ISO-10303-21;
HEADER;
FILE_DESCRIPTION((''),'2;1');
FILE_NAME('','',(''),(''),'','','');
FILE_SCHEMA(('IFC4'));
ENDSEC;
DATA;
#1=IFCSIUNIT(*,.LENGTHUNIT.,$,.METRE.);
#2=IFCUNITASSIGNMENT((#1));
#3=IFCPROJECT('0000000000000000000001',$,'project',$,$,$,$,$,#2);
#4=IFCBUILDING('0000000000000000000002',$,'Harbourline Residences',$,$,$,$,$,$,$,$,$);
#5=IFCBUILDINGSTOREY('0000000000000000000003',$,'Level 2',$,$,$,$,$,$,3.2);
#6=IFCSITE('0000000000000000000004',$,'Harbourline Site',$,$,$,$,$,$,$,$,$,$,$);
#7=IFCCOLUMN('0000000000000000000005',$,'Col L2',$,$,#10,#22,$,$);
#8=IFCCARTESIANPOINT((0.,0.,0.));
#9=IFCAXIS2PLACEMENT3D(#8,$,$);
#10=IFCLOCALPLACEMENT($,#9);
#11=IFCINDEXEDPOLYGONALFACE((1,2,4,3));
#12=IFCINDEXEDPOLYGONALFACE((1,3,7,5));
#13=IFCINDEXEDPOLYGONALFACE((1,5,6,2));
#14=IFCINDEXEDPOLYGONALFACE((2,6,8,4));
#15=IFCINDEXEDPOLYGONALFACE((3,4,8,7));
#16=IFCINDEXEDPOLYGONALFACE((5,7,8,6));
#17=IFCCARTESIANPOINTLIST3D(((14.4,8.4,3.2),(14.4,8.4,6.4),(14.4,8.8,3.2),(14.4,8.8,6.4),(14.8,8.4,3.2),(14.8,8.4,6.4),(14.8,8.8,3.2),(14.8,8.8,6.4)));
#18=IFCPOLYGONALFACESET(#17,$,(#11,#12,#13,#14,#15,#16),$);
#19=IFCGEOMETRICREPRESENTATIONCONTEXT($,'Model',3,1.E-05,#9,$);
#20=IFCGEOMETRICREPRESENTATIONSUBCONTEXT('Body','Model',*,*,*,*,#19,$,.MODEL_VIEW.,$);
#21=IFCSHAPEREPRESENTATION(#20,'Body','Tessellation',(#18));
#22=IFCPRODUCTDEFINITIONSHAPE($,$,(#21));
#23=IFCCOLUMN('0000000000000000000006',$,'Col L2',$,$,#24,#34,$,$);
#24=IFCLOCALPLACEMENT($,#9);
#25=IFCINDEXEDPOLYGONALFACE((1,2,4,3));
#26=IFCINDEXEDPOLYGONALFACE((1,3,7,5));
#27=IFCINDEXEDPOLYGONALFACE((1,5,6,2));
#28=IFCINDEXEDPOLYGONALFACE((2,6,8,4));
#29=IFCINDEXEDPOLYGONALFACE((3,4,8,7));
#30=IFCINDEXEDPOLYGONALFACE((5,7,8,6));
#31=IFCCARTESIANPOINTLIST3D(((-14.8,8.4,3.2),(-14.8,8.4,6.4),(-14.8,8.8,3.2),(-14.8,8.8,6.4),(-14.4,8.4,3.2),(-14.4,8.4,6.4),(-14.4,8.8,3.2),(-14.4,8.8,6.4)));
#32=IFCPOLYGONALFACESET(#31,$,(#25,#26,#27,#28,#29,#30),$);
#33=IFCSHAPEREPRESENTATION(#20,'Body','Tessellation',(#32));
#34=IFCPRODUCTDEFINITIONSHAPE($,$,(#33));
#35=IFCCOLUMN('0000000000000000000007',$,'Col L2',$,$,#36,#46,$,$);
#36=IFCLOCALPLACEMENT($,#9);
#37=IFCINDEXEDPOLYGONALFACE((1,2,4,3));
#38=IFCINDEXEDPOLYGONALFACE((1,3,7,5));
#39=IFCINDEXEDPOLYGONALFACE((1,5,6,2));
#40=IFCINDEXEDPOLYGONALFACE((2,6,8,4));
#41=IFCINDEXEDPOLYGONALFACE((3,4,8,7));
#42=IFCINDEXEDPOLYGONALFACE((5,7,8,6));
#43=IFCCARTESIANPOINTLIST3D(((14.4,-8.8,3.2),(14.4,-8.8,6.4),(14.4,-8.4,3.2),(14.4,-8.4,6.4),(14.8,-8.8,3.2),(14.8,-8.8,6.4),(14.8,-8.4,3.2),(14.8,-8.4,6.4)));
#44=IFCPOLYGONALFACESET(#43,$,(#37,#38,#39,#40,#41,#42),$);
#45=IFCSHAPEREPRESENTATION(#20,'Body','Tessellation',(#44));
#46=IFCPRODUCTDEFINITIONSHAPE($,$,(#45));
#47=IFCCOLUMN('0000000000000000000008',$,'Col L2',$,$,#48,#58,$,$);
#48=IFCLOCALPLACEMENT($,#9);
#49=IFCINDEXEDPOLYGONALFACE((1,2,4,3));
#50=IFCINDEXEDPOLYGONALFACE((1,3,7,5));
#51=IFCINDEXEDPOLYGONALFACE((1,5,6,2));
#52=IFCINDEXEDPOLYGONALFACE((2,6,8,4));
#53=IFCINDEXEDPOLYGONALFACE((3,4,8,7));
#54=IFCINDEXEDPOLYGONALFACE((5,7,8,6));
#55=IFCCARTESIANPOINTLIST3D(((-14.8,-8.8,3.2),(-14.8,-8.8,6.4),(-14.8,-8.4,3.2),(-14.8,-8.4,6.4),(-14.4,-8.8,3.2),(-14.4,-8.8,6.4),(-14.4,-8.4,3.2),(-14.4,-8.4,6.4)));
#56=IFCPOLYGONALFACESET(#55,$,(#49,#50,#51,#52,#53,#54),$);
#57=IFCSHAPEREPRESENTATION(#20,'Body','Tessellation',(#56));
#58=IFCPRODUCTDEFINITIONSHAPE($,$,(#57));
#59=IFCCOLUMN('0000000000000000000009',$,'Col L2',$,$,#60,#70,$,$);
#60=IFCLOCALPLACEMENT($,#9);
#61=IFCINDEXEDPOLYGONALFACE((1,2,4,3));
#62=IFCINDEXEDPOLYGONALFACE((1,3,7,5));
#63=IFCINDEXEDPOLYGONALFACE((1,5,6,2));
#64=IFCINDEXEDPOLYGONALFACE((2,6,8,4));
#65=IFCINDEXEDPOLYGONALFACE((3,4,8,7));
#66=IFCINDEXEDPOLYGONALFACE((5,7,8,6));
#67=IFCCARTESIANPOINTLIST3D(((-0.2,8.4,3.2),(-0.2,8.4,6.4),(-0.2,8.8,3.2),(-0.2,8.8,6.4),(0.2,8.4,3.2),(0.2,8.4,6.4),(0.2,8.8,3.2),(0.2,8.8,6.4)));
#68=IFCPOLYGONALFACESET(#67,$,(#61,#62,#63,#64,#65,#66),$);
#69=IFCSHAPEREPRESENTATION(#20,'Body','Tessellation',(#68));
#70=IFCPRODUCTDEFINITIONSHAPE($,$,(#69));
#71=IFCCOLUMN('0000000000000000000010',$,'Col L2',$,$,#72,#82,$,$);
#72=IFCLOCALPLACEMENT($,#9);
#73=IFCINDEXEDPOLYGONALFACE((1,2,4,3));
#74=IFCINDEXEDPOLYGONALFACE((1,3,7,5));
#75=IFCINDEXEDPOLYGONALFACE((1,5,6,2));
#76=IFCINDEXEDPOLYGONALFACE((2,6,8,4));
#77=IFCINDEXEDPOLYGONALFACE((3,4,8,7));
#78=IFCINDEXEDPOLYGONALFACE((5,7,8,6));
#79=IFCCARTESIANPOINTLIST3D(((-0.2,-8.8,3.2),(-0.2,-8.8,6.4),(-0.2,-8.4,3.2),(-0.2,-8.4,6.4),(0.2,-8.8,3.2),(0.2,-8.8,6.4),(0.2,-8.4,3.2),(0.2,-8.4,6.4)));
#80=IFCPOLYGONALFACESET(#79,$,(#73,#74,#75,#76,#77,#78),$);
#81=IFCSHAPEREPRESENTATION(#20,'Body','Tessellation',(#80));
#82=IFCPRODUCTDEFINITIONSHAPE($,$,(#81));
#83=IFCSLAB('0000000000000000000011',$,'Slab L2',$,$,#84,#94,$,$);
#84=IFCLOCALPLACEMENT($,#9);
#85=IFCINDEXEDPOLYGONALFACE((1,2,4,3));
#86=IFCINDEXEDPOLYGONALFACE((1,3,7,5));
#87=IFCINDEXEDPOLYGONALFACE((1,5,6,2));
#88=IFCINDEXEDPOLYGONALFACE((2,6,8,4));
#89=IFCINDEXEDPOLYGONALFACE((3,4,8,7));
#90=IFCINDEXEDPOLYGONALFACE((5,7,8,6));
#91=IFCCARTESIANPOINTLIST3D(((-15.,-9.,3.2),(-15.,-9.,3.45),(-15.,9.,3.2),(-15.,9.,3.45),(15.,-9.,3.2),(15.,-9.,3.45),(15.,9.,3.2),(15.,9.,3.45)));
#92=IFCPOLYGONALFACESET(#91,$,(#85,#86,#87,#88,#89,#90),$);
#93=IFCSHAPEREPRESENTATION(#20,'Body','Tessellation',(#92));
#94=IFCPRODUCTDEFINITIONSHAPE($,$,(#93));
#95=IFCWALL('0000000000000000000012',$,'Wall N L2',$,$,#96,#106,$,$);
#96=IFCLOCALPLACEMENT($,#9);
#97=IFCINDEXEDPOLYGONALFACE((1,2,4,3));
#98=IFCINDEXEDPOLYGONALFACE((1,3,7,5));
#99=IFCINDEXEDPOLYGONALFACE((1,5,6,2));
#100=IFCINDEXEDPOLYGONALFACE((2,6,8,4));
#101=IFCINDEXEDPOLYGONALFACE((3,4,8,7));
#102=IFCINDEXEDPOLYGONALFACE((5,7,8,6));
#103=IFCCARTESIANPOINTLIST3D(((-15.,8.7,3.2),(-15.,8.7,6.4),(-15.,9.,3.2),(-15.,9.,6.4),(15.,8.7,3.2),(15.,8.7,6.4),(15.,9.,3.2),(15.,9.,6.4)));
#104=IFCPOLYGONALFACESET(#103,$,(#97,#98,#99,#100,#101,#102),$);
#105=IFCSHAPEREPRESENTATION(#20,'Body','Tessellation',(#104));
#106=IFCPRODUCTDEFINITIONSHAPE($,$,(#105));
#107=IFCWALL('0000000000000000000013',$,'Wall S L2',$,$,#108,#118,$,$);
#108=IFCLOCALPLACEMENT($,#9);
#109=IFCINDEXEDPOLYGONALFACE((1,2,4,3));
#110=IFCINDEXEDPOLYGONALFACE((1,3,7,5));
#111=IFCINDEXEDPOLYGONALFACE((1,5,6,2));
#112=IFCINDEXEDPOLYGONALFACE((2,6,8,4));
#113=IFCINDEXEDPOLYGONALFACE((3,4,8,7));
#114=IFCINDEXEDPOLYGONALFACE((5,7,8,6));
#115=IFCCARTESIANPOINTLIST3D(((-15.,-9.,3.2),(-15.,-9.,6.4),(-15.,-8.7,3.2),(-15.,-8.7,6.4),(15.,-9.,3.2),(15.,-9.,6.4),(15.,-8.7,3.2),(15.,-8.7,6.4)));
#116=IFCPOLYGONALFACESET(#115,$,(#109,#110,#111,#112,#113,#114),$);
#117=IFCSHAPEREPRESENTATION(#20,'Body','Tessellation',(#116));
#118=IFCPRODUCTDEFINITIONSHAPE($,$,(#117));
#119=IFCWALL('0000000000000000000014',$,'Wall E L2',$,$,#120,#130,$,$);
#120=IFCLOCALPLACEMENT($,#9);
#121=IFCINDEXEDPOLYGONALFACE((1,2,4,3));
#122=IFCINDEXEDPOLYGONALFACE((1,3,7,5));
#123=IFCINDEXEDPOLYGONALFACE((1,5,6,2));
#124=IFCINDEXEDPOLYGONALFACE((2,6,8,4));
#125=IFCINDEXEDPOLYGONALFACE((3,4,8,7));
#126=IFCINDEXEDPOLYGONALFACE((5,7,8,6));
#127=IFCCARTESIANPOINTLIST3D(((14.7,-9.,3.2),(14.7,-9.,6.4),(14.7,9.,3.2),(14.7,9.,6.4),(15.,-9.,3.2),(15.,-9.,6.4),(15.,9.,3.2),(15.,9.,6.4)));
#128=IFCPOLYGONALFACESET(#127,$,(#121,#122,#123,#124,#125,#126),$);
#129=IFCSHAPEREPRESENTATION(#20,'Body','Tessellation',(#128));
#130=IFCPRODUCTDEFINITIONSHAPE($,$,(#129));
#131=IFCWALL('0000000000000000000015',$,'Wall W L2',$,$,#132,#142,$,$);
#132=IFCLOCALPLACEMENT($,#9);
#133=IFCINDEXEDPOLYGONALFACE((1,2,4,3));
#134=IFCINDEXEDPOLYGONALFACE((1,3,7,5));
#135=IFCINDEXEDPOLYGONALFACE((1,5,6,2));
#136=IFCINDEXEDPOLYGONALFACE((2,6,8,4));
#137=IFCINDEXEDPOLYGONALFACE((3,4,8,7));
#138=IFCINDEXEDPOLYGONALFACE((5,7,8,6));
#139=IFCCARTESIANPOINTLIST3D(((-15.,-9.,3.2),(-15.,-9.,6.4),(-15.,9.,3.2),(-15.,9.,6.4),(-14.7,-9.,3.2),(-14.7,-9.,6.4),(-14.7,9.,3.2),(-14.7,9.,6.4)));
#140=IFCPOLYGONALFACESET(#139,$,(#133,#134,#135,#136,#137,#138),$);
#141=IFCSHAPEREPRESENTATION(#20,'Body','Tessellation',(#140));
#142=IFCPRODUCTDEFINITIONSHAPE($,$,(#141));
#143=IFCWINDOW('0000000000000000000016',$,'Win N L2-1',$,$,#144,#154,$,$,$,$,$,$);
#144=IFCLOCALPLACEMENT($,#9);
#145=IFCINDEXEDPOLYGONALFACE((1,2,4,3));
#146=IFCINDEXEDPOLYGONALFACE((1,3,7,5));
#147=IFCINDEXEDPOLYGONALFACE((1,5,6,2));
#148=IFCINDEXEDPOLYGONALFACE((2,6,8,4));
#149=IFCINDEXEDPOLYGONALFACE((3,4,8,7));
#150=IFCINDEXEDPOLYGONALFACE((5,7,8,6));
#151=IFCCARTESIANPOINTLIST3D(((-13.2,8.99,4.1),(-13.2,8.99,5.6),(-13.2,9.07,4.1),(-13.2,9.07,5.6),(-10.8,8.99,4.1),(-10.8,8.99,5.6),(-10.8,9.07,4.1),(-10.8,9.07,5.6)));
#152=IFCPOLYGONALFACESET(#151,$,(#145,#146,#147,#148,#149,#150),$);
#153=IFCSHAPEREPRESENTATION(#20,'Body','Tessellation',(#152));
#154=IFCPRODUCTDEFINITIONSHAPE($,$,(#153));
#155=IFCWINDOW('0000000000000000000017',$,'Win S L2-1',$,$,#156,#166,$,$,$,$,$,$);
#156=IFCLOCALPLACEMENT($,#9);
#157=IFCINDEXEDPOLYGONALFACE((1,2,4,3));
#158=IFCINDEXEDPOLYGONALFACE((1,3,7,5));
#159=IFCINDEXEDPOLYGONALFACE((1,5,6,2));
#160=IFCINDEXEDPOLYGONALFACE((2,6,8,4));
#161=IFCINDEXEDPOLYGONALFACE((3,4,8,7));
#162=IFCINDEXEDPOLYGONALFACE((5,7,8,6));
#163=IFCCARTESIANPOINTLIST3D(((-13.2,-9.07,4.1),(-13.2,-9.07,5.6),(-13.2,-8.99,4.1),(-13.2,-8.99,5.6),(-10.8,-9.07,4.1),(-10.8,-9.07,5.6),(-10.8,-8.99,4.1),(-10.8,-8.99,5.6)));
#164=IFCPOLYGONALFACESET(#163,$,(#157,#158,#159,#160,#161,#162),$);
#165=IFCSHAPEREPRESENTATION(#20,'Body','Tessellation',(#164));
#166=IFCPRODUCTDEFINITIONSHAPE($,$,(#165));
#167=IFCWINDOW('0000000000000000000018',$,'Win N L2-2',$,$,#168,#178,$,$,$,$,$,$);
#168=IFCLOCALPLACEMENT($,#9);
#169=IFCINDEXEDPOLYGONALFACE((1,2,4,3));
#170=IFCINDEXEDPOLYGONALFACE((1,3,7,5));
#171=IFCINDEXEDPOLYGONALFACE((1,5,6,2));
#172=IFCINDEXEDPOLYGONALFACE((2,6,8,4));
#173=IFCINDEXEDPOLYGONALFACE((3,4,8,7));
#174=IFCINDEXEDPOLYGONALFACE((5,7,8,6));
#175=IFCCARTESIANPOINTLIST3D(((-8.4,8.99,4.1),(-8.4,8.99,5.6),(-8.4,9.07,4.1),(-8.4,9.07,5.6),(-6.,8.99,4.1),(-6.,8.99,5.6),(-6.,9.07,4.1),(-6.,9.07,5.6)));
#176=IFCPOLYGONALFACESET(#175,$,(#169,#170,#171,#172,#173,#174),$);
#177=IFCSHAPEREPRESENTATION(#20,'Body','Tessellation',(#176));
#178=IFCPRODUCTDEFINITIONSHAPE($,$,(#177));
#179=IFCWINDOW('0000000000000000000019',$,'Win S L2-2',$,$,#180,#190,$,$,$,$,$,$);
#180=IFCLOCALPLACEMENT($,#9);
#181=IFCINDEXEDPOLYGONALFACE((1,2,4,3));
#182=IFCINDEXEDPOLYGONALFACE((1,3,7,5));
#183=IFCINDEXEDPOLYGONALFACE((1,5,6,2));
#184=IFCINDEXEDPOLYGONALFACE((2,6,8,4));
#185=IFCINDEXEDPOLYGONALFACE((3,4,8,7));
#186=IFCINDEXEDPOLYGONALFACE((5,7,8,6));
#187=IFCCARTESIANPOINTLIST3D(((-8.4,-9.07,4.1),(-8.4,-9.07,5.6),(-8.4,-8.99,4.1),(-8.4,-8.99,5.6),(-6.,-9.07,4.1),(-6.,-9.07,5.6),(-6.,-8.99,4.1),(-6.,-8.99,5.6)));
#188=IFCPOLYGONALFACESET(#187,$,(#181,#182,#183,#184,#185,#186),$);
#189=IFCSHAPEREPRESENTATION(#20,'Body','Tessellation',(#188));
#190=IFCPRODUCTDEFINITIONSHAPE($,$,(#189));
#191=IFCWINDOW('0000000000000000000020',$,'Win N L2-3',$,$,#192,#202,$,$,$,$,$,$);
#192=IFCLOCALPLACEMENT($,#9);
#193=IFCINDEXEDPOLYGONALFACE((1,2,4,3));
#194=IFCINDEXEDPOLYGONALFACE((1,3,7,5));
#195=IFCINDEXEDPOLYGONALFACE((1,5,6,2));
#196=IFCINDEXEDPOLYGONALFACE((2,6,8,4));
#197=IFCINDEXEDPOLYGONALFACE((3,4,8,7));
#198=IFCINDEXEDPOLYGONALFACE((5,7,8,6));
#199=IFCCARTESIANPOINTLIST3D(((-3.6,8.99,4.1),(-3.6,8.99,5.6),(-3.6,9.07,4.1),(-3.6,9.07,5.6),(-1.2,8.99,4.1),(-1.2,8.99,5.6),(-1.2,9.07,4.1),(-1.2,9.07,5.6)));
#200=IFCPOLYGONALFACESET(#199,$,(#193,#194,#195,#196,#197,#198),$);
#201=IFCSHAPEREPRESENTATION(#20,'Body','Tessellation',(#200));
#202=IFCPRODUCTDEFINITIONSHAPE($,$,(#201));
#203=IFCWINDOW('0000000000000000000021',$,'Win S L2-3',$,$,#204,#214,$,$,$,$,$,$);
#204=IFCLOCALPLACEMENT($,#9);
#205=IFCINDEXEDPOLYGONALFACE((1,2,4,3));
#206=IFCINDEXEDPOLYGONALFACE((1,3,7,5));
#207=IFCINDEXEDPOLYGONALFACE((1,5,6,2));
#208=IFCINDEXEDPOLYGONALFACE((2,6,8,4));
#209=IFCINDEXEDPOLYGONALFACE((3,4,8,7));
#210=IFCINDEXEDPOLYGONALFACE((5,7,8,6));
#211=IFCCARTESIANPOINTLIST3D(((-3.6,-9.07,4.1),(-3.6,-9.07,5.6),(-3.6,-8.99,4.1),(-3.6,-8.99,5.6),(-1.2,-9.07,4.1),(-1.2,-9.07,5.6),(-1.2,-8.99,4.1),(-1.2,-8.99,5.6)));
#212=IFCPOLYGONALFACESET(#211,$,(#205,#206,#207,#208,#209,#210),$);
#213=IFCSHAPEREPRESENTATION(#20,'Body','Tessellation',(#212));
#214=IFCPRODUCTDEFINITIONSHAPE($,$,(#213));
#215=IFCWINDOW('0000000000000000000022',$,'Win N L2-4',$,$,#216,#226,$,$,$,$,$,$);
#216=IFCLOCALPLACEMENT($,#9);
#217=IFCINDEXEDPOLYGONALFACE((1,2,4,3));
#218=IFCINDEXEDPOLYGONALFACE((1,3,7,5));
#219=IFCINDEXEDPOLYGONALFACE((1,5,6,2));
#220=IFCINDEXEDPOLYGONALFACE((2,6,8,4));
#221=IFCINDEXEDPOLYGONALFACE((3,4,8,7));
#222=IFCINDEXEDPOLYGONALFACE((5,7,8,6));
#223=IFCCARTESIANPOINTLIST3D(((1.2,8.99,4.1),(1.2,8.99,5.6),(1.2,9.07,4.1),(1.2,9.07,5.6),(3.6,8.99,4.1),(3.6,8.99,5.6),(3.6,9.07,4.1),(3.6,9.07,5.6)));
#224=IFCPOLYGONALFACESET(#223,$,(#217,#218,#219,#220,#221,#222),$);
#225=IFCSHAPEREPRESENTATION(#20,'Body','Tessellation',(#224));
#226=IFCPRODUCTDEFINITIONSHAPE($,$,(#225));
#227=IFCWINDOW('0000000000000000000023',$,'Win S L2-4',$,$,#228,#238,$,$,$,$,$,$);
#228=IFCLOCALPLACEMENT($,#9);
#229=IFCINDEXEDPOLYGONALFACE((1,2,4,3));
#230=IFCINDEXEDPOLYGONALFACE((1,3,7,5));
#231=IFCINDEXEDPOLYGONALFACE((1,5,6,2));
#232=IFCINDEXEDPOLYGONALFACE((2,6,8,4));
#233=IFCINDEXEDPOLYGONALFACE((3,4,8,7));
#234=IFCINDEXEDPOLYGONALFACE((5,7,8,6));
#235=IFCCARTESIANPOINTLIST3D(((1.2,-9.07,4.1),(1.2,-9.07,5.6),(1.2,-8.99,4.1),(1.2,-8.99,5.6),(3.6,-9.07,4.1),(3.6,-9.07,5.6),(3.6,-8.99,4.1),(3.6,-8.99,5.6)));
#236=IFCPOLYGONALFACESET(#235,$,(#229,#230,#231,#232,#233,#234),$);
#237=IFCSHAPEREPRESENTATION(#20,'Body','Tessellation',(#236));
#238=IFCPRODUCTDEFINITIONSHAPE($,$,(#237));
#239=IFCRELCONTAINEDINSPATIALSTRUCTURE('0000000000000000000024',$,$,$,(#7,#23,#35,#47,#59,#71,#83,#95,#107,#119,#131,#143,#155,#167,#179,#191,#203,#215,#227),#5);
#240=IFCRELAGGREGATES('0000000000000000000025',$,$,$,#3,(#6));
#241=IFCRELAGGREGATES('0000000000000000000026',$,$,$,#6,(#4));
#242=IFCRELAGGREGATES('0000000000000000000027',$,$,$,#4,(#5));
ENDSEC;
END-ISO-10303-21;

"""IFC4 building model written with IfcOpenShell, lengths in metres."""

from ifc_helpers import new_model, si_unit, frame, frame_2d, origin, origin_2d, context, subcontext, project, spatial, rectangle, extrude, element, save


model = new_model("IFC4")

# Units and contexts
model_context = context("Model", 3, precision=1e-05, world=origin())
body_context = subcontext(model_context, "Body", "Model", "MODEL_VIEW")
ifc_project = project(units=[si_unit("LENGTHUNIT", "METRE")])

# Site, building, storey
site = spatial("IfcSite", under=ifc_project, Name="Harbourline Site")
building = spatial("IfcBuilding", under=site, Name="Harbourline Residences")
storey = spatial("IfcBuildingStorey", under=building, Name="Level 2", Elevation=3.2)

# Columns
element("IfcColumn", 1, inside=storey, Name="Col L2", context=body_context, shape_type="SweptSolid", body=[
    extrude(rectangle(XDim=0.4, YDim=0.4, at=frame_2d((14.6, 8.6))), frame((0.0, 0.0, 3.2)), (0.0, 0.0, 1.0), 3.2),
])
element("IfcColumn", 2, inside=storey, Name="Col L2", context=body_context, shape_type="SweptSolid", body=[
    extrude(rectangle(XDim=0.4, YDim=0.4, at=frame_2d((-14.6, 8.6))), frame((0.0, 0.0, 3.2)), (0.0, 0.0, 1.0), 3.2),
])
element("IfcColumn", 3, inside=storey, Name="Col L2", context=body_context, shape_type="SweptSolid", body=[
    extrude(rectangle(XDim=0.4, YDim=0.4, at=frame_2d((14.6, -8.6))), frame((0.0, 0.0, 3.2)), (0.0, 0.0, 1.0), 3.2),
])
element("IfcColumn", 4, inside=storey, Name="Col L2", context=body_context, shape_type="SweptSolid", body=[
    extrude(rectangle(XDim=0.4, YDim=0.4, at=frame_2d((-14.6, -8.6))), frame((0.0, 0.0, 3.2)), (0.0, 0.0, 1.0), 3.2),
])
element("IfcColumn", 5, inside=storey, Name="Col L2", context=body_context, shape_type="SweptSolid", body=[
    extrude(rectangle(XDim=0.4, YDim=0.4, at=frame_2d((0.0, 8.6))), frame((0.0, 0.0, 3.2)), (0.0, 0.0, 1.0), 3.2),
])
element("IfcColumn", 6, inside=storey, Name="Col L2", context=body_context, shape_type="SweptSolid", body=[
    extrude(rectangle(XDim=0.4, YDim=0.4, at=frame_2d((0.0, -8.6))), frame((0.0, 0.0, 3.2)), (0.0, 0.0, 1.0), 3.2),
])

# Slab
element("IfcSlab", 7, inside=storey, Name="Slab L2", context=body_context, shape_type="SweptSolid", body=[
    extrude(rectangle(XDim=30.0, YDim=18.0, at=origin_2d()), frame((0.0, 0.0, 3.2)), (0.0, 0.0, 1.0), 0.25),
])

# Walls
element("IfcWall", 8, inside=storey, Name="Wall N L2", context=body_context, shape_type="SweptSolid", body=[
    extrude(rectangle(XDim=30.0, YDim=0.3, at=frame_2d((0.0, 8.85))), frame((0.0, 0.0, 3.2)), (0.0, 0.0, 1.0), 3.2),
])
element("IfcWall", 9, inside=storey, Name="Wall S L2", context=body_context, shape_type="SweptSolid", body=[
    extrude(rectangle(XDim=30.0, YDim=0.3, at=frame_2d((0.0, -8.85))), frame((0.0, 0.0, 3.2)), (0.0, 0.0, 1.0), 3.2),
])
element("IfcWall", 10, inside=storey, Name="Wall E L2", context=body_context, shape_type="SweptSolid", body=[
    extrude(rectangle(XDim=0.3, YDim=18.0, at=frame_2d((14.85, 0.0))), frame((0.0, 0.0, 3.2)), (0.0, 0.0, 1.0), 3.2),
])
element("IfcWall", 11, inside=storey, Name="Wall W L2", context=body_context, shape_type="SweptSolid", body=[
    extrude(rectangle(XDim=0.3, YDim=18.0, at=frame_2d((-14.85, 0.0))), frame((0.0, 0.0, 3.2)), (0.0, 0.0, 1.0), 3.2),
])

# Windows
element("IfcWindow", 12, inside=storey, Name="Win N L2-1", context=body_context, shape_type="SweptSolid", body=[
    extrude(rectangle(XDim=2.4, YDim=0.08, at=frame_2d((-12.0, 9.03))), frame((0.0, 0.0, 4.1)), (0.0, 0.0, 1.0), 1.5),
])
element("IfcWindow", 13, inside=storey, Name="Win S L2-1", context=body_context, shape_type="SweptSolid", body=[
    extrude(rectangle(XDim=2.4, YDim=0.08, at=frame_2d((-12.0, -9.03))), frame((0.0, 0.0, 4.1)), (0.0, 0.0, 1.0), 1.5),
])
element("IfcWindow", 14, inside=storey, Name="Win N L2-2", context=body_context, shape_type="SweptSolid", body=[
    extrude(rectangle(XDim=2.4, YDim=0.08, at=frame_2d((-7.2, 9.03))), frame((0.0, 0.0, 4.1)), (0.0, 0.0, 1.0), 1.5),
])
element("IfcWindow", 15, inside=storey, Name="Win S L2-2", context=body_context, shape_type="SweptSolid", body=[
    extrude(rectangle(XDim=2.4, YDim=0.08, at=frame_2d((-7.2, -9.03))), frame((0.0, 0.0, 4.1)), (0.0, 0.0, 1.0), 1.5),
])
element("IfcWindow", 16, inside=storey, Name="Win N L2-3", context=body_context, shape_type="SweptSolid", body=[
    extrude(rectangle(XDim=2.4, YDim=0.08, at=frame_2d((-2.4, 9.03))), frame((0.0, 0.0, 4.1)), (0.0, 0.0, 1.0), 1.5),
])
element("IfcWindow", 17, inside=storey, Name="Win S L2-3", context=body_context, shape_type="SweptSolid", body=[
    extrude(rectangle(XDim=2.4, YDim=0.08, at=frame_2d((-2.4, -9.03))), frame((0.0, 0.0, 4.1)), (0.0, 0.0, 1.0), 1.5),
])
element("IfcWindow", 18, inside=storey, Name="Win N L2-4", context=body_context, shape_type="SweptSolid", body=[
    extrude(rectangle(XDim=2.4, YDim=0.08, at=frame_2d((2.4, 9.03))), frame((0.0, 0.0, 4.1)), (0.0, 0.0, 1.0), 1.5),
])
element("IfcWindow", 19, inside=storey, Name="Win S L2-4", context=body_context, shape_type="SweptSolid", body=[
    extrude(rectangle(XDim=2.4, YDim=0.08, at=frame_2d((2.4, -9.03))), frame((0.0, 0.0, 4.1)), (0.0, 0.0, 1.0), 1.5),
])

save(model, "model.ifc")
